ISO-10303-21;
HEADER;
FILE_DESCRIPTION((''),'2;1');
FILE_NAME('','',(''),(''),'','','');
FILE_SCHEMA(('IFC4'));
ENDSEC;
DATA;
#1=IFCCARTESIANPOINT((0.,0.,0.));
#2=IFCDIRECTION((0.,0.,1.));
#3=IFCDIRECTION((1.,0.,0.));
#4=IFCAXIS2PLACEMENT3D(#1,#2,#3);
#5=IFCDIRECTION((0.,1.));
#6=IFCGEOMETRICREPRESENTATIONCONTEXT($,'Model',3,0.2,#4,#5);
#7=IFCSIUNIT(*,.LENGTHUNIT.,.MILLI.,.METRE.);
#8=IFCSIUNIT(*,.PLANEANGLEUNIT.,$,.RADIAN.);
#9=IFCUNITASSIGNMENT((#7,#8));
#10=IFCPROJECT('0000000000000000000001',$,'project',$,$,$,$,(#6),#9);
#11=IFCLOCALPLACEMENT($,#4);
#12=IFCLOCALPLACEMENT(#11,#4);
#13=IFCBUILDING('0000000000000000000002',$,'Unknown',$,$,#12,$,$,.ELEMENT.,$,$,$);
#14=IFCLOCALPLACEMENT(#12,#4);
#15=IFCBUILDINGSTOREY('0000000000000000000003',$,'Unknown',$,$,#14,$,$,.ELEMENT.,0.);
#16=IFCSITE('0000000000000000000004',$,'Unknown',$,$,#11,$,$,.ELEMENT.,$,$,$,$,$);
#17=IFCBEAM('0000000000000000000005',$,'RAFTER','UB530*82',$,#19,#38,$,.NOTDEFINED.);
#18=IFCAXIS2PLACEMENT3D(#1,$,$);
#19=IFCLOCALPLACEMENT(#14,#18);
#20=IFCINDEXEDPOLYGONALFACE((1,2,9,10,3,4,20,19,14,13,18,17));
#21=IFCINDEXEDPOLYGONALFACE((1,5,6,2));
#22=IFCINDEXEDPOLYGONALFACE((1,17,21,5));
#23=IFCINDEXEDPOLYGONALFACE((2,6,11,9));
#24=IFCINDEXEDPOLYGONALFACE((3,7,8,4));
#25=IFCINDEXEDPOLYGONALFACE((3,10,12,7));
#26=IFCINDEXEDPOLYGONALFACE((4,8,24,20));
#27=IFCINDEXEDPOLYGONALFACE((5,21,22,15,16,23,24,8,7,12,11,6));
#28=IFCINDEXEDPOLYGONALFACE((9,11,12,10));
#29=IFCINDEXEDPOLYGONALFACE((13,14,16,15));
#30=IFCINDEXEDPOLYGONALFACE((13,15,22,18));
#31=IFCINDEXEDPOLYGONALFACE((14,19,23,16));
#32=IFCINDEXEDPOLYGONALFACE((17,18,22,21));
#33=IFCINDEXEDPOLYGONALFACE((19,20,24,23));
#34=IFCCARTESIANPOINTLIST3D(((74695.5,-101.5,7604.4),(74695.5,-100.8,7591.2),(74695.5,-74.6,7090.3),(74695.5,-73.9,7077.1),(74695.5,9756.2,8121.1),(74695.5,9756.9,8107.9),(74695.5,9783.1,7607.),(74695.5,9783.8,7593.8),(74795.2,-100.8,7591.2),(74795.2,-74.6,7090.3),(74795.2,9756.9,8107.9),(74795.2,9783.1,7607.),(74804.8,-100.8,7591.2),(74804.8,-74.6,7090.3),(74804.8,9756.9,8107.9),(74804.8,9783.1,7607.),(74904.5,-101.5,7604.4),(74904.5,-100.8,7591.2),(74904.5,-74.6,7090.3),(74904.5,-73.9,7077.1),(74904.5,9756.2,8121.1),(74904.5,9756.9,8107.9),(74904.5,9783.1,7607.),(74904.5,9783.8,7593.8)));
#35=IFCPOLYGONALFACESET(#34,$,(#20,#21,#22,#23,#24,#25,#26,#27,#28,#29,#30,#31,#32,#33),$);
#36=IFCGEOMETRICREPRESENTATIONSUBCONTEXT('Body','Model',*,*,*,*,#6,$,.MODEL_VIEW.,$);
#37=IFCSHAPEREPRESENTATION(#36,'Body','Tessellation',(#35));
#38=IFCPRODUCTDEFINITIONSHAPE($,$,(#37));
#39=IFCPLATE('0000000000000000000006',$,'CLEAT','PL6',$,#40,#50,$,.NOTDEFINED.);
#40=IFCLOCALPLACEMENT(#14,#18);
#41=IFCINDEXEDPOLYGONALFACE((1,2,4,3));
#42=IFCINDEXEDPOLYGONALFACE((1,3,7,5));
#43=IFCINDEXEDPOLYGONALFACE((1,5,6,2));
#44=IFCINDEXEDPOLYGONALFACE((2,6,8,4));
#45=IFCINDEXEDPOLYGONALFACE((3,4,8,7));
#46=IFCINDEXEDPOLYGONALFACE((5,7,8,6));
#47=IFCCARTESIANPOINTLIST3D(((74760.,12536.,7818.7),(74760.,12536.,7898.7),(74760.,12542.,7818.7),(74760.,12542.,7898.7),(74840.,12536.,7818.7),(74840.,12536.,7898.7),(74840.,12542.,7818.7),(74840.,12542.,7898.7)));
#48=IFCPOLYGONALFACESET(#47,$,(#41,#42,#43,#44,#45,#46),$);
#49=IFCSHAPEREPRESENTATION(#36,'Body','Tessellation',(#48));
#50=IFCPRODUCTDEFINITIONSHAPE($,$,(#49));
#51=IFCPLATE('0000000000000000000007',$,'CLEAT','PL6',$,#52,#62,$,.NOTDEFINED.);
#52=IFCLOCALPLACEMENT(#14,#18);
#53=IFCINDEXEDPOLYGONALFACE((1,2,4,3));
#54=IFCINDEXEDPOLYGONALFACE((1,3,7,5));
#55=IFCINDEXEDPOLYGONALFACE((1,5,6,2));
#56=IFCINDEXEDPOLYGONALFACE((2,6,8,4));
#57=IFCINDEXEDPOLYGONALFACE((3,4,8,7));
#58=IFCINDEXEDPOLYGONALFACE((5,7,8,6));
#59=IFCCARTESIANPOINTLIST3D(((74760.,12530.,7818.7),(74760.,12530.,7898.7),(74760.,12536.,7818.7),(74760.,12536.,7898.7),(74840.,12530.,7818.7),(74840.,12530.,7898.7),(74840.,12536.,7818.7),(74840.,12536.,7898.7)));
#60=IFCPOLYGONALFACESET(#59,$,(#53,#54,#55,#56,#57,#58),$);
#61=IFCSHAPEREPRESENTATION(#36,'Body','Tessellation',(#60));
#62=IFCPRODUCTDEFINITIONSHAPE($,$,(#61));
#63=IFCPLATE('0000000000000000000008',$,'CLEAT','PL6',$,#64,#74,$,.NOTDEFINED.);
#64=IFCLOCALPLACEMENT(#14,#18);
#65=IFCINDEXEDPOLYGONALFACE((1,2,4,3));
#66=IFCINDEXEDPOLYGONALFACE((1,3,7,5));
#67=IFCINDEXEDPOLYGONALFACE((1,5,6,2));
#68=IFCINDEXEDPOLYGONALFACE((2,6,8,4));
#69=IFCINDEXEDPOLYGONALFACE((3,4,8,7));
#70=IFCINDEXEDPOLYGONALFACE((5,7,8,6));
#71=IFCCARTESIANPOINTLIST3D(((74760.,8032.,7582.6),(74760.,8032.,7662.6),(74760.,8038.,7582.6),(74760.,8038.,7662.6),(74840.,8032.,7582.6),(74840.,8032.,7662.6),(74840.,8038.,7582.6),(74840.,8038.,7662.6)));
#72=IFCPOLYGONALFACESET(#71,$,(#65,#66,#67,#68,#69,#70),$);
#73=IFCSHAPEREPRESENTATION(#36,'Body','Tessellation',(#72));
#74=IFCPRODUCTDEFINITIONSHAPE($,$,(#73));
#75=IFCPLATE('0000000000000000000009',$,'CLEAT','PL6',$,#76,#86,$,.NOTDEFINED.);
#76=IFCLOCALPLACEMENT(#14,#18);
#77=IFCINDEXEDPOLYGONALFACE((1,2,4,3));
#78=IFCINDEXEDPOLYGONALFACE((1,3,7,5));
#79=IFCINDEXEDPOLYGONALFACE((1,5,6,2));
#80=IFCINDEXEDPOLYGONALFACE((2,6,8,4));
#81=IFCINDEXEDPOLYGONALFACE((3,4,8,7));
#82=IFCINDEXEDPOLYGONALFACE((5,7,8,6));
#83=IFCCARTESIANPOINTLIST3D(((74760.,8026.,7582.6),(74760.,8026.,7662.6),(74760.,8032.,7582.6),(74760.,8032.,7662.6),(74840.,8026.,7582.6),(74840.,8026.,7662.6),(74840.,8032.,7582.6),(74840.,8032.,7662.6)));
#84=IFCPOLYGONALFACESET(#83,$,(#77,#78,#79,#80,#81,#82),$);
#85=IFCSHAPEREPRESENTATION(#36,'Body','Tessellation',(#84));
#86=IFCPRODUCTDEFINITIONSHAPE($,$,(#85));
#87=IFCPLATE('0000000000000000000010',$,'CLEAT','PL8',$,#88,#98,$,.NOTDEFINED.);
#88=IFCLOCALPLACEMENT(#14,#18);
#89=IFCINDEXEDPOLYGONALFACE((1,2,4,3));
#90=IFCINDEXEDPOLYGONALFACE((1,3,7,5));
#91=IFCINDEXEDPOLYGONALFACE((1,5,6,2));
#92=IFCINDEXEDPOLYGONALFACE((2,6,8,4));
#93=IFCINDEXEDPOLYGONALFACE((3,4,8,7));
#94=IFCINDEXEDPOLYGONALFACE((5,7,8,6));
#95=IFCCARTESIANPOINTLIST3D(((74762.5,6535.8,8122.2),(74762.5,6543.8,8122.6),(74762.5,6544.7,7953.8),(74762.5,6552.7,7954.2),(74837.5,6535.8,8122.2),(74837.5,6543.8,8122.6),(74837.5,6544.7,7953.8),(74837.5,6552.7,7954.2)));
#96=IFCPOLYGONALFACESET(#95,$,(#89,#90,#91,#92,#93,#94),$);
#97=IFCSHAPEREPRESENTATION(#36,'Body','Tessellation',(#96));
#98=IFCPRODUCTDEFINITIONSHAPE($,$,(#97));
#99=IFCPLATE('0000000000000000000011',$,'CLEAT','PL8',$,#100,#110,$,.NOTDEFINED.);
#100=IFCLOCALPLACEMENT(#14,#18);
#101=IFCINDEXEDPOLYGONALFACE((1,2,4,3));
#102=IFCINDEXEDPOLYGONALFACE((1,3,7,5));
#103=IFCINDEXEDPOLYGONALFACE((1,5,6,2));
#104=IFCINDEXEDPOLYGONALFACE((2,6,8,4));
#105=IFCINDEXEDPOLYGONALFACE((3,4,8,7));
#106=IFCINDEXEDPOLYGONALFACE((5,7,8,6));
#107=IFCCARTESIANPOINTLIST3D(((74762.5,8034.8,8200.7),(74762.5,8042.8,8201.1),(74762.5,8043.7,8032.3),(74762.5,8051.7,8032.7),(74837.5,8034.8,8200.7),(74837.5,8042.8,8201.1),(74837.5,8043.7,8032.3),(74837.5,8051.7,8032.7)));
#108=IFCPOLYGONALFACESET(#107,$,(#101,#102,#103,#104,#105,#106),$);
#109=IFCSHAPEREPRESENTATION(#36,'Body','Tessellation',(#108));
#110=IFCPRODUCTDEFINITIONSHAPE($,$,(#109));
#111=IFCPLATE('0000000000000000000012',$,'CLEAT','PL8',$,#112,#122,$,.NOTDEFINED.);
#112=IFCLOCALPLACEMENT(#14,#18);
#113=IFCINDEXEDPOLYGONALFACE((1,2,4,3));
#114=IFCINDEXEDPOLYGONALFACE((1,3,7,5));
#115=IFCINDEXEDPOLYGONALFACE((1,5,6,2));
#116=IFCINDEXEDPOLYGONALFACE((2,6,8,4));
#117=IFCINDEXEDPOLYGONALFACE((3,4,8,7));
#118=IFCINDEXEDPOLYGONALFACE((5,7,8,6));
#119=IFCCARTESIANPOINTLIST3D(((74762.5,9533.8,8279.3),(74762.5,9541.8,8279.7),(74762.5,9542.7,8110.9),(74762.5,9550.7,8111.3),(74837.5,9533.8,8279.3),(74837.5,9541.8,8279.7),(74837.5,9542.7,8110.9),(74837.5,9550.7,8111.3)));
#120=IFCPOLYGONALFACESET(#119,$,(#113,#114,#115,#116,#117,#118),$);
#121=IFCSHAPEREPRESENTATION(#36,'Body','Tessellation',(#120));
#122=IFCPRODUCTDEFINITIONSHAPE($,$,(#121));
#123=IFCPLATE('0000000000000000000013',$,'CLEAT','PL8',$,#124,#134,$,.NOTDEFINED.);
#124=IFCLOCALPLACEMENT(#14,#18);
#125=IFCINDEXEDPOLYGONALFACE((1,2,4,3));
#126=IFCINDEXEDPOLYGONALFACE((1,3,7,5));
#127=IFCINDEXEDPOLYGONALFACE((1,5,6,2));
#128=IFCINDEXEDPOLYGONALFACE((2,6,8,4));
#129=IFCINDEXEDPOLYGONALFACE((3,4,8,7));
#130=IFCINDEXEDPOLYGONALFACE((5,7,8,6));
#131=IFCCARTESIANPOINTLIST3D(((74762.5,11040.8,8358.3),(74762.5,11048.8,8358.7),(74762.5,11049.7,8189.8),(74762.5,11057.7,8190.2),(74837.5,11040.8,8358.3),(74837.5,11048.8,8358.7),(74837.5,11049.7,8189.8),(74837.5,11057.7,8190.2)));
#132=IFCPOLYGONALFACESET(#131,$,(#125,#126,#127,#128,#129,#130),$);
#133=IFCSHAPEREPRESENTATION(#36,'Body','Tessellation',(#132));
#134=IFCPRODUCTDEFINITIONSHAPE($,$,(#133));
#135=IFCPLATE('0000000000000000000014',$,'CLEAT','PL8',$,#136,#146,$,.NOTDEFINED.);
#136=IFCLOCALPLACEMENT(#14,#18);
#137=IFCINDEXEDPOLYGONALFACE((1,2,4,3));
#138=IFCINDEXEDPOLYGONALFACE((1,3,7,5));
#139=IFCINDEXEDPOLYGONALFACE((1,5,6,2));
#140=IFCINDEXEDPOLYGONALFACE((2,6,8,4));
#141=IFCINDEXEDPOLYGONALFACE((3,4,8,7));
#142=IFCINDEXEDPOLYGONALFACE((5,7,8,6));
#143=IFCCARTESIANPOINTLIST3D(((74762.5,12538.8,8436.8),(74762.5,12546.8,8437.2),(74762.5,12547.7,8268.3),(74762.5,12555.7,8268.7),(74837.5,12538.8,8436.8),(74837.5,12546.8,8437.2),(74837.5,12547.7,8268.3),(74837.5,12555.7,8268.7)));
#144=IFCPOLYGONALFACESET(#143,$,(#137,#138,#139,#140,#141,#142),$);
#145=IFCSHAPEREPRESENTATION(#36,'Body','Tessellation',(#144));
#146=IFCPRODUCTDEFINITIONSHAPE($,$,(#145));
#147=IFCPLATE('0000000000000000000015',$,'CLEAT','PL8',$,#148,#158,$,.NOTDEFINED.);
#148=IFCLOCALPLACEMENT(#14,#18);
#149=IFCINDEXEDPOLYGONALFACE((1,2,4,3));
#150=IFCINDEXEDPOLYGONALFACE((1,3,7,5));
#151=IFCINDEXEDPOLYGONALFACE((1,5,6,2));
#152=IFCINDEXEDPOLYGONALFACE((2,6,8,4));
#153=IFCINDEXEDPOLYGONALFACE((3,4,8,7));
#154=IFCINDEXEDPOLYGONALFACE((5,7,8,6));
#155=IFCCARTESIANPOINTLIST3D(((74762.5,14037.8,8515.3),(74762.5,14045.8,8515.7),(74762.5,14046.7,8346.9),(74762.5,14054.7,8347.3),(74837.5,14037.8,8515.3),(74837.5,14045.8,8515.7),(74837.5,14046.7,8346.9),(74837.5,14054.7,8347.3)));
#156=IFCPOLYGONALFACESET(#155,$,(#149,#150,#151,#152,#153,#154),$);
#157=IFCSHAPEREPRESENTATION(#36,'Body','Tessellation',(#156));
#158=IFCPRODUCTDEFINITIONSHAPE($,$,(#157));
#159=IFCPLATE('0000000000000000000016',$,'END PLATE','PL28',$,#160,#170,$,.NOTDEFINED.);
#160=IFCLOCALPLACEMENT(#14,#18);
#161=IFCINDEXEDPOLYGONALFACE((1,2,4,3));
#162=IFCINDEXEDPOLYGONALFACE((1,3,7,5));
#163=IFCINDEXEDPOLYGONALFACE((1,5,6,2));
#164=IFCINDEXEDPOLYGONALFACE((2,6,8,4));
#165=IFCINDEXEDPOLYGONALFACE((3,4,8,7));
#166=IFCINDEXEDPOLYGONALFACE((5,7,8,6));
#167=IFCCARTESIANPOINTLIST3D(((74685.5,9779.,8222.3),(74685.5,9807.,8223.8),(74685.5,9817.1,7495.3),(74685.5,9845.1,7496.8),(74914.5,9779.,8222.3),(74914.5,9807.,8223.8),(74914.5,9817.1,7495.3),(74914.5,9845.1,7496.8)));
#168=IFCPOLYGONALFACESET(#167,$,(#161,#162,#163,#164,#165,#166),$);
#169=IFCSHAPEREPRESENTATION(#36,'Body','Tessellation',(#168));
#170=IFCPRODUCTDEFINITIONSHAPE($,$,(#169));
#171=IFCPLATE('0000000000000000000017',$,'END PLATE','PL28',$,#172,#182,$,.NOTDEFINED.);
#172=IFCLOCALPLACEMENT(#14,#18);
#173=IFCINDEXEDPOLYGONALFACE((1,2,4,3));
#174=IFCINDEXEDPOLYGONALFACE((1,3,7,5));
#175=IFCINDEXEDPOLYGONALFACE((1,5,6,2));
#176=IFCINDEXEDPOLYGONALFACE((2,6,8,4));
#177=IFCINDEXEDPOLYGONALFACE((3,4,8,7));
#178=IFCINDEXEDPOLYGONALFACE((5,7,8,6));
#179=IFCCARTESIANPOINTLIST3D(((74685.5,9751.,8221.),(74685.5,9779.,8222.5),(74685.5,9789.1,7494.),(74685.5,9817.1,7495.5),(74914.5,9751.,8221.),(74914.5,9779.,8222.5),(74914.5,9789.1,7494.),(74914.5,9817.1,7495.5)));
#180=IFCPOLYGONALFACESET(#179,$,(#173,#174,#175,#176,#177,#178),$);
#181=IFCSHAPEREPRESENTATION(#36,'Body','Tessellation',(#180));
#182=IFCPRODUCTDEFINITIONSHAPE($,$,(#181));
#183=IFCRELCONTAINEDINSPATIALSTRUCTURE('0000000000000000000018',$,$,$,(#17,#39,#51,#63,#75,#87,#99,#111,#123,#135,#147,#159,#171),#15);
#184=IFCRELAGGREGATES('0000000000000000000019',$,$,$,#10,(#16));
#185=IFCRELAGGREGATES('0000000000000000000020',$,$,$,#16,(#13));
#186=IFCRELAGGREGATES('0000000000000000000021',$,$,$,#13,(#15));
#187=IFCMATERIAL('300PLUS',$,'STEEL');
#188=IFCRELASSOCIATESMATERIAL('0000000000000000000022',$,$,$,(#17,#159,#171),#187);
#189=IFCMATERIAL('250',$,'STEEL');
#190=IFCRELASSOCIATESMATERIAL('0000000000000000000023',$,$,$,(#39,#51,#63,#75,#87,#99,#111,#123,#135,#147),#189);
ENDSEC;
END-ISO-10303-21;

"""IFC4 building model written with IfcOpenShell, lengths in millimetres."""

from ifc_helpers import new_model, si_unit, direction, frame, origin_with_axes, place, context, subcontext, project, spatial, line, indexed_curve, outline, extrude, material, element, save


model = new_model("IFC4")

# Units and contexts
model_context = context("Model", 3, precision=0.2, world=origin_with_axes(), true_north=direction((0.0, 1.0)))
body_context = subcontext(model_context, "Body", "Model", "MODEL_VIEW")
ifc_project = project(units=[si_unit("LENGTHUNIT", "METRE", prefix="MILLI"), si_unit("PLANEANGLEUNIT", "RADIAN")], contexts=[model_context])

# Site, building, storey
site_placement = place(None, origin_with_axes())
site = spatial("IfcSite", under=ifc_project, at=site_placement, Name="Unknown", CompositionType="ELEMENT")
building_placement = place(site_placement, origin_with_axes())
building = spatial("IfcBuilding", under=site, at=building_placement, Name="Unknown", CompositionType="ELEMENT")
storey_placement = place(building_placement, origin_with_axes())
storey = spatial("IfcBuildingStorey", under=building, at=storey_placement, Name="Unknown", CompositionType="ELEMENT", Elevation=0.0)

# Shared definitions
ifc_material_1 = material(Name="300PLUS", Category="STEEL")

# Beam
beam_1_placement = place(storey_placement, frame((74800.0, 9770.0, 7857.5), z_axis=(-1.0, 0.0, 0.0), x_axis=(0.0, -0.998629, -0.052344)))
element("IfcBeam", 1, at=beam_1_placement, inside=storey, material=ifc_material_1, Name="RAFTER", Description="UB530*82", PredefinedType="NOTDEFINED", context=body_context, shape_type="SolidModel", body=[
    extrude(outline(indexed_curve([(-104.5, -264.0), (104.5, -264.0), (104.5, -250.8), (4.8, -250.8), (4.8, 250.8), (104.5, 250.8), (104.5, 264.0), (-104.5, 264.0), (-104.5, 250.8), (-4.8, 250.8), (-4.8, -250.8), (-104.5, -250.8)], segments=[line(1, 2, 3, 4, 5, 6, 7, 8, 9, 10, 11, 12, 1)])), frame((0.0, 0.0, 0.0), z_axis=(-1.0, 0.0, 0.0), x_axis=(0.0, 0.0, 1.0)), (0.0, 0.0, -1.0), 9871.2),
])

# Plates
ifc_material_2 = material(Name="250", Category="STEEL")
for number, where, z_axis, x_axis, name in (
    (2, (74840.0, 12539.0, 7818.7), (0.0, 1.0, 0.0), (-1.0, 0.0, 0.0), "CLEAT"),
    (3, (74760.0, 12533.0, 7818.7), (0.0, -1.0, 0.0), (1.0, 0.0, 0.0), "CLEAT"),
    (4, (74840.0, 8035.0, 7582.6), (0.0, 1.0, 0.0), (-1.0, 0.0, 0.0), "CLEAT"),
    (5, (74760.0, 8029.0, 7582.6), (0.0, -1.0, 0.0), (1.0, 0.0, 0.0), "CLEAT"),
):
    element("IfcPlate", number, at=place(storey_placement, frame(where, z_axis=z_axis, x_axis=x_axis)), inside=storey, material=ifc_material_2, Name=name, Description="PL6", PredefinedType="NOTDEFINED", context=body_context, shape_type="SolidModel", body=[
        extrude(outline(indexed_curve([(0.0, 0.0), (80.0, 0.0), (80.0, 80.0), (0.0, 80.0)], segments=[line(1, 2, 3, 4, 1)])), frame((0.0, 0.0, 3.0), z_axis=(0.0, 0.0, 1.0), x_axis=(1.0, 0.0, 0.0)), (0.0, 0.0, -1.0), 6.0),
    ])
for number, where, z_axis, x_axis, name in (
    (6, (74762.5, 6539.8, 8122.4), (0.0, 0.998606, 0.052777), (1.0, 0.0, 0.0), "CLEAT"),
    (7, (74762.5, 8038.8, 8200.9), (0.0, 0.998606, 0.052777), (1.0, 0.0, 0.0), "CLEAT"),
    (8, (74762.5, 9537.8, 8279.5), (0.0, 0.998606, 0.052777), (1.0, 0.0, 0.0), "CLEAT"),
):
    element("IfcPlate", number, at=place(storey_placement, frame(where, z_axis=z_axis, x_axis=x_axis)), inside=storey, material=ifc_material_2, Name=name, Description="PL8", PredefinedType="NOTDEFINED", context=body_context, shape_type="SolidModel", body=[
        extrude(outline(indexed_curve([(0.0, 0.0), (75.0, 0.0), (75.0, 168.6), (0.0, 168.6)], segments=[line(1, 2, 3, 4, 1)])), frame((0.0, 0.0, 4.0), z_axis=(0.0, 0.0, 1.0), x_axis=(1.0, 0.0, 0.0)), (0.0, 0.0, -1.0), 8.0),
    ])
for number, where, z_axis, x_axis, name in (
    (9, (74762.5, 11044.8, 8358.5), (0.0, 0.998608, 0.052745), (1.0, 0.0, 0.0), "CLEAT"),
    (10, (74762.5, 12542.8, 8437.0), (0.0, 0.998608, 0.052745), (1.0, 0.0, 0.0), "CLEAT"),
):
    element("IfcPlate", number, at=place(storey_placement, frame(where, z_axis=z_axis, x_axis=x_axis)), inside=storey, material=ifc_material_2, Name=name, Description="PL8", PredefinedType="NOTDEFINED", context=body_context, shape_type="SolidModel", body=[
        extrude(outline(indexed_curve([(0.0, 0.0), (75.0, 0.0), (75.0, 168.7), (0.0, 168.7)], segments=[line(1, 2, 3, 4, 1)])), frame((0.0, 0.0, 4.0), z_axis=(0.0, 0.0, 1.0), x_axis=(1.0, 0.0, 0.0)), (0.0, 0.0, -1.0), 8.0),
    ])
plate_placement = place(storey_placement, frame((74762.5, 14041.8, 8515.5), z_axis=(0.0, 0.998606, 0.052777), x_axis=(1.0, 0.0, 0.0)))
element("IfcPlate", 11, at=plate_placement, inside=storey, material=ifc_material_2, Name="CLEAT", Description="PL8", PredefinedType="NOTDEFINED", context=body_context, shape_type="SolidModel", body=[
    extrude(outline(indexed_curve([(0.0, 0.0), (75.0, 0.0), (75.0, 168.6), (0.0, 168.6)], segments=[line(1, 2, 3, 4, 1)])), frame((0.0, 0.0, 4.0), z_axis=(0.0, 0.0, 1.0), x_axis=(1.0, 0.0, 0.0)), (0.0, 0.0, -1.0), 8.0),
])
for number, where, z_axis, x_axis, name in (
    (12, (74914.5, 9831.1, 7496.0), (0.0, 0.99863, 0.052335), (-1.0, 0.0, 0.0), "END PLATE"),
    (13, (74914.5, 9803.1, 7494.7), (0.0, 0.99863, 0.052335), (-1.0, 0.0, 0.0), "END PLATE"),
):
    element("IfcPlate", number, at=place(storey_placement, frame(where, z_axis=z_axis, x_axis=x_axis)), inside=storey, material=ifc_material_1, Name=name, Description="PL28", PredefinedType="NOTDEFINED", context=body_context, shape_type="SolidModel", body=[
        extrude(outline(indexed_curve([(0.0, 0.0), (229.0, 0.0), (229.0, 728.0), (0.0, 728.0)], segments=[line(1, 2, 3, 4, 1)])), frame((0.0, 0.0, 14.0), z_axis=(0.0, 0.0, 1.0), x_axis=(1.0, 0.0, 0.0)), (0.0, 0.0, -1.0), 28.0),
    ])

save(model, "model.ifc")
